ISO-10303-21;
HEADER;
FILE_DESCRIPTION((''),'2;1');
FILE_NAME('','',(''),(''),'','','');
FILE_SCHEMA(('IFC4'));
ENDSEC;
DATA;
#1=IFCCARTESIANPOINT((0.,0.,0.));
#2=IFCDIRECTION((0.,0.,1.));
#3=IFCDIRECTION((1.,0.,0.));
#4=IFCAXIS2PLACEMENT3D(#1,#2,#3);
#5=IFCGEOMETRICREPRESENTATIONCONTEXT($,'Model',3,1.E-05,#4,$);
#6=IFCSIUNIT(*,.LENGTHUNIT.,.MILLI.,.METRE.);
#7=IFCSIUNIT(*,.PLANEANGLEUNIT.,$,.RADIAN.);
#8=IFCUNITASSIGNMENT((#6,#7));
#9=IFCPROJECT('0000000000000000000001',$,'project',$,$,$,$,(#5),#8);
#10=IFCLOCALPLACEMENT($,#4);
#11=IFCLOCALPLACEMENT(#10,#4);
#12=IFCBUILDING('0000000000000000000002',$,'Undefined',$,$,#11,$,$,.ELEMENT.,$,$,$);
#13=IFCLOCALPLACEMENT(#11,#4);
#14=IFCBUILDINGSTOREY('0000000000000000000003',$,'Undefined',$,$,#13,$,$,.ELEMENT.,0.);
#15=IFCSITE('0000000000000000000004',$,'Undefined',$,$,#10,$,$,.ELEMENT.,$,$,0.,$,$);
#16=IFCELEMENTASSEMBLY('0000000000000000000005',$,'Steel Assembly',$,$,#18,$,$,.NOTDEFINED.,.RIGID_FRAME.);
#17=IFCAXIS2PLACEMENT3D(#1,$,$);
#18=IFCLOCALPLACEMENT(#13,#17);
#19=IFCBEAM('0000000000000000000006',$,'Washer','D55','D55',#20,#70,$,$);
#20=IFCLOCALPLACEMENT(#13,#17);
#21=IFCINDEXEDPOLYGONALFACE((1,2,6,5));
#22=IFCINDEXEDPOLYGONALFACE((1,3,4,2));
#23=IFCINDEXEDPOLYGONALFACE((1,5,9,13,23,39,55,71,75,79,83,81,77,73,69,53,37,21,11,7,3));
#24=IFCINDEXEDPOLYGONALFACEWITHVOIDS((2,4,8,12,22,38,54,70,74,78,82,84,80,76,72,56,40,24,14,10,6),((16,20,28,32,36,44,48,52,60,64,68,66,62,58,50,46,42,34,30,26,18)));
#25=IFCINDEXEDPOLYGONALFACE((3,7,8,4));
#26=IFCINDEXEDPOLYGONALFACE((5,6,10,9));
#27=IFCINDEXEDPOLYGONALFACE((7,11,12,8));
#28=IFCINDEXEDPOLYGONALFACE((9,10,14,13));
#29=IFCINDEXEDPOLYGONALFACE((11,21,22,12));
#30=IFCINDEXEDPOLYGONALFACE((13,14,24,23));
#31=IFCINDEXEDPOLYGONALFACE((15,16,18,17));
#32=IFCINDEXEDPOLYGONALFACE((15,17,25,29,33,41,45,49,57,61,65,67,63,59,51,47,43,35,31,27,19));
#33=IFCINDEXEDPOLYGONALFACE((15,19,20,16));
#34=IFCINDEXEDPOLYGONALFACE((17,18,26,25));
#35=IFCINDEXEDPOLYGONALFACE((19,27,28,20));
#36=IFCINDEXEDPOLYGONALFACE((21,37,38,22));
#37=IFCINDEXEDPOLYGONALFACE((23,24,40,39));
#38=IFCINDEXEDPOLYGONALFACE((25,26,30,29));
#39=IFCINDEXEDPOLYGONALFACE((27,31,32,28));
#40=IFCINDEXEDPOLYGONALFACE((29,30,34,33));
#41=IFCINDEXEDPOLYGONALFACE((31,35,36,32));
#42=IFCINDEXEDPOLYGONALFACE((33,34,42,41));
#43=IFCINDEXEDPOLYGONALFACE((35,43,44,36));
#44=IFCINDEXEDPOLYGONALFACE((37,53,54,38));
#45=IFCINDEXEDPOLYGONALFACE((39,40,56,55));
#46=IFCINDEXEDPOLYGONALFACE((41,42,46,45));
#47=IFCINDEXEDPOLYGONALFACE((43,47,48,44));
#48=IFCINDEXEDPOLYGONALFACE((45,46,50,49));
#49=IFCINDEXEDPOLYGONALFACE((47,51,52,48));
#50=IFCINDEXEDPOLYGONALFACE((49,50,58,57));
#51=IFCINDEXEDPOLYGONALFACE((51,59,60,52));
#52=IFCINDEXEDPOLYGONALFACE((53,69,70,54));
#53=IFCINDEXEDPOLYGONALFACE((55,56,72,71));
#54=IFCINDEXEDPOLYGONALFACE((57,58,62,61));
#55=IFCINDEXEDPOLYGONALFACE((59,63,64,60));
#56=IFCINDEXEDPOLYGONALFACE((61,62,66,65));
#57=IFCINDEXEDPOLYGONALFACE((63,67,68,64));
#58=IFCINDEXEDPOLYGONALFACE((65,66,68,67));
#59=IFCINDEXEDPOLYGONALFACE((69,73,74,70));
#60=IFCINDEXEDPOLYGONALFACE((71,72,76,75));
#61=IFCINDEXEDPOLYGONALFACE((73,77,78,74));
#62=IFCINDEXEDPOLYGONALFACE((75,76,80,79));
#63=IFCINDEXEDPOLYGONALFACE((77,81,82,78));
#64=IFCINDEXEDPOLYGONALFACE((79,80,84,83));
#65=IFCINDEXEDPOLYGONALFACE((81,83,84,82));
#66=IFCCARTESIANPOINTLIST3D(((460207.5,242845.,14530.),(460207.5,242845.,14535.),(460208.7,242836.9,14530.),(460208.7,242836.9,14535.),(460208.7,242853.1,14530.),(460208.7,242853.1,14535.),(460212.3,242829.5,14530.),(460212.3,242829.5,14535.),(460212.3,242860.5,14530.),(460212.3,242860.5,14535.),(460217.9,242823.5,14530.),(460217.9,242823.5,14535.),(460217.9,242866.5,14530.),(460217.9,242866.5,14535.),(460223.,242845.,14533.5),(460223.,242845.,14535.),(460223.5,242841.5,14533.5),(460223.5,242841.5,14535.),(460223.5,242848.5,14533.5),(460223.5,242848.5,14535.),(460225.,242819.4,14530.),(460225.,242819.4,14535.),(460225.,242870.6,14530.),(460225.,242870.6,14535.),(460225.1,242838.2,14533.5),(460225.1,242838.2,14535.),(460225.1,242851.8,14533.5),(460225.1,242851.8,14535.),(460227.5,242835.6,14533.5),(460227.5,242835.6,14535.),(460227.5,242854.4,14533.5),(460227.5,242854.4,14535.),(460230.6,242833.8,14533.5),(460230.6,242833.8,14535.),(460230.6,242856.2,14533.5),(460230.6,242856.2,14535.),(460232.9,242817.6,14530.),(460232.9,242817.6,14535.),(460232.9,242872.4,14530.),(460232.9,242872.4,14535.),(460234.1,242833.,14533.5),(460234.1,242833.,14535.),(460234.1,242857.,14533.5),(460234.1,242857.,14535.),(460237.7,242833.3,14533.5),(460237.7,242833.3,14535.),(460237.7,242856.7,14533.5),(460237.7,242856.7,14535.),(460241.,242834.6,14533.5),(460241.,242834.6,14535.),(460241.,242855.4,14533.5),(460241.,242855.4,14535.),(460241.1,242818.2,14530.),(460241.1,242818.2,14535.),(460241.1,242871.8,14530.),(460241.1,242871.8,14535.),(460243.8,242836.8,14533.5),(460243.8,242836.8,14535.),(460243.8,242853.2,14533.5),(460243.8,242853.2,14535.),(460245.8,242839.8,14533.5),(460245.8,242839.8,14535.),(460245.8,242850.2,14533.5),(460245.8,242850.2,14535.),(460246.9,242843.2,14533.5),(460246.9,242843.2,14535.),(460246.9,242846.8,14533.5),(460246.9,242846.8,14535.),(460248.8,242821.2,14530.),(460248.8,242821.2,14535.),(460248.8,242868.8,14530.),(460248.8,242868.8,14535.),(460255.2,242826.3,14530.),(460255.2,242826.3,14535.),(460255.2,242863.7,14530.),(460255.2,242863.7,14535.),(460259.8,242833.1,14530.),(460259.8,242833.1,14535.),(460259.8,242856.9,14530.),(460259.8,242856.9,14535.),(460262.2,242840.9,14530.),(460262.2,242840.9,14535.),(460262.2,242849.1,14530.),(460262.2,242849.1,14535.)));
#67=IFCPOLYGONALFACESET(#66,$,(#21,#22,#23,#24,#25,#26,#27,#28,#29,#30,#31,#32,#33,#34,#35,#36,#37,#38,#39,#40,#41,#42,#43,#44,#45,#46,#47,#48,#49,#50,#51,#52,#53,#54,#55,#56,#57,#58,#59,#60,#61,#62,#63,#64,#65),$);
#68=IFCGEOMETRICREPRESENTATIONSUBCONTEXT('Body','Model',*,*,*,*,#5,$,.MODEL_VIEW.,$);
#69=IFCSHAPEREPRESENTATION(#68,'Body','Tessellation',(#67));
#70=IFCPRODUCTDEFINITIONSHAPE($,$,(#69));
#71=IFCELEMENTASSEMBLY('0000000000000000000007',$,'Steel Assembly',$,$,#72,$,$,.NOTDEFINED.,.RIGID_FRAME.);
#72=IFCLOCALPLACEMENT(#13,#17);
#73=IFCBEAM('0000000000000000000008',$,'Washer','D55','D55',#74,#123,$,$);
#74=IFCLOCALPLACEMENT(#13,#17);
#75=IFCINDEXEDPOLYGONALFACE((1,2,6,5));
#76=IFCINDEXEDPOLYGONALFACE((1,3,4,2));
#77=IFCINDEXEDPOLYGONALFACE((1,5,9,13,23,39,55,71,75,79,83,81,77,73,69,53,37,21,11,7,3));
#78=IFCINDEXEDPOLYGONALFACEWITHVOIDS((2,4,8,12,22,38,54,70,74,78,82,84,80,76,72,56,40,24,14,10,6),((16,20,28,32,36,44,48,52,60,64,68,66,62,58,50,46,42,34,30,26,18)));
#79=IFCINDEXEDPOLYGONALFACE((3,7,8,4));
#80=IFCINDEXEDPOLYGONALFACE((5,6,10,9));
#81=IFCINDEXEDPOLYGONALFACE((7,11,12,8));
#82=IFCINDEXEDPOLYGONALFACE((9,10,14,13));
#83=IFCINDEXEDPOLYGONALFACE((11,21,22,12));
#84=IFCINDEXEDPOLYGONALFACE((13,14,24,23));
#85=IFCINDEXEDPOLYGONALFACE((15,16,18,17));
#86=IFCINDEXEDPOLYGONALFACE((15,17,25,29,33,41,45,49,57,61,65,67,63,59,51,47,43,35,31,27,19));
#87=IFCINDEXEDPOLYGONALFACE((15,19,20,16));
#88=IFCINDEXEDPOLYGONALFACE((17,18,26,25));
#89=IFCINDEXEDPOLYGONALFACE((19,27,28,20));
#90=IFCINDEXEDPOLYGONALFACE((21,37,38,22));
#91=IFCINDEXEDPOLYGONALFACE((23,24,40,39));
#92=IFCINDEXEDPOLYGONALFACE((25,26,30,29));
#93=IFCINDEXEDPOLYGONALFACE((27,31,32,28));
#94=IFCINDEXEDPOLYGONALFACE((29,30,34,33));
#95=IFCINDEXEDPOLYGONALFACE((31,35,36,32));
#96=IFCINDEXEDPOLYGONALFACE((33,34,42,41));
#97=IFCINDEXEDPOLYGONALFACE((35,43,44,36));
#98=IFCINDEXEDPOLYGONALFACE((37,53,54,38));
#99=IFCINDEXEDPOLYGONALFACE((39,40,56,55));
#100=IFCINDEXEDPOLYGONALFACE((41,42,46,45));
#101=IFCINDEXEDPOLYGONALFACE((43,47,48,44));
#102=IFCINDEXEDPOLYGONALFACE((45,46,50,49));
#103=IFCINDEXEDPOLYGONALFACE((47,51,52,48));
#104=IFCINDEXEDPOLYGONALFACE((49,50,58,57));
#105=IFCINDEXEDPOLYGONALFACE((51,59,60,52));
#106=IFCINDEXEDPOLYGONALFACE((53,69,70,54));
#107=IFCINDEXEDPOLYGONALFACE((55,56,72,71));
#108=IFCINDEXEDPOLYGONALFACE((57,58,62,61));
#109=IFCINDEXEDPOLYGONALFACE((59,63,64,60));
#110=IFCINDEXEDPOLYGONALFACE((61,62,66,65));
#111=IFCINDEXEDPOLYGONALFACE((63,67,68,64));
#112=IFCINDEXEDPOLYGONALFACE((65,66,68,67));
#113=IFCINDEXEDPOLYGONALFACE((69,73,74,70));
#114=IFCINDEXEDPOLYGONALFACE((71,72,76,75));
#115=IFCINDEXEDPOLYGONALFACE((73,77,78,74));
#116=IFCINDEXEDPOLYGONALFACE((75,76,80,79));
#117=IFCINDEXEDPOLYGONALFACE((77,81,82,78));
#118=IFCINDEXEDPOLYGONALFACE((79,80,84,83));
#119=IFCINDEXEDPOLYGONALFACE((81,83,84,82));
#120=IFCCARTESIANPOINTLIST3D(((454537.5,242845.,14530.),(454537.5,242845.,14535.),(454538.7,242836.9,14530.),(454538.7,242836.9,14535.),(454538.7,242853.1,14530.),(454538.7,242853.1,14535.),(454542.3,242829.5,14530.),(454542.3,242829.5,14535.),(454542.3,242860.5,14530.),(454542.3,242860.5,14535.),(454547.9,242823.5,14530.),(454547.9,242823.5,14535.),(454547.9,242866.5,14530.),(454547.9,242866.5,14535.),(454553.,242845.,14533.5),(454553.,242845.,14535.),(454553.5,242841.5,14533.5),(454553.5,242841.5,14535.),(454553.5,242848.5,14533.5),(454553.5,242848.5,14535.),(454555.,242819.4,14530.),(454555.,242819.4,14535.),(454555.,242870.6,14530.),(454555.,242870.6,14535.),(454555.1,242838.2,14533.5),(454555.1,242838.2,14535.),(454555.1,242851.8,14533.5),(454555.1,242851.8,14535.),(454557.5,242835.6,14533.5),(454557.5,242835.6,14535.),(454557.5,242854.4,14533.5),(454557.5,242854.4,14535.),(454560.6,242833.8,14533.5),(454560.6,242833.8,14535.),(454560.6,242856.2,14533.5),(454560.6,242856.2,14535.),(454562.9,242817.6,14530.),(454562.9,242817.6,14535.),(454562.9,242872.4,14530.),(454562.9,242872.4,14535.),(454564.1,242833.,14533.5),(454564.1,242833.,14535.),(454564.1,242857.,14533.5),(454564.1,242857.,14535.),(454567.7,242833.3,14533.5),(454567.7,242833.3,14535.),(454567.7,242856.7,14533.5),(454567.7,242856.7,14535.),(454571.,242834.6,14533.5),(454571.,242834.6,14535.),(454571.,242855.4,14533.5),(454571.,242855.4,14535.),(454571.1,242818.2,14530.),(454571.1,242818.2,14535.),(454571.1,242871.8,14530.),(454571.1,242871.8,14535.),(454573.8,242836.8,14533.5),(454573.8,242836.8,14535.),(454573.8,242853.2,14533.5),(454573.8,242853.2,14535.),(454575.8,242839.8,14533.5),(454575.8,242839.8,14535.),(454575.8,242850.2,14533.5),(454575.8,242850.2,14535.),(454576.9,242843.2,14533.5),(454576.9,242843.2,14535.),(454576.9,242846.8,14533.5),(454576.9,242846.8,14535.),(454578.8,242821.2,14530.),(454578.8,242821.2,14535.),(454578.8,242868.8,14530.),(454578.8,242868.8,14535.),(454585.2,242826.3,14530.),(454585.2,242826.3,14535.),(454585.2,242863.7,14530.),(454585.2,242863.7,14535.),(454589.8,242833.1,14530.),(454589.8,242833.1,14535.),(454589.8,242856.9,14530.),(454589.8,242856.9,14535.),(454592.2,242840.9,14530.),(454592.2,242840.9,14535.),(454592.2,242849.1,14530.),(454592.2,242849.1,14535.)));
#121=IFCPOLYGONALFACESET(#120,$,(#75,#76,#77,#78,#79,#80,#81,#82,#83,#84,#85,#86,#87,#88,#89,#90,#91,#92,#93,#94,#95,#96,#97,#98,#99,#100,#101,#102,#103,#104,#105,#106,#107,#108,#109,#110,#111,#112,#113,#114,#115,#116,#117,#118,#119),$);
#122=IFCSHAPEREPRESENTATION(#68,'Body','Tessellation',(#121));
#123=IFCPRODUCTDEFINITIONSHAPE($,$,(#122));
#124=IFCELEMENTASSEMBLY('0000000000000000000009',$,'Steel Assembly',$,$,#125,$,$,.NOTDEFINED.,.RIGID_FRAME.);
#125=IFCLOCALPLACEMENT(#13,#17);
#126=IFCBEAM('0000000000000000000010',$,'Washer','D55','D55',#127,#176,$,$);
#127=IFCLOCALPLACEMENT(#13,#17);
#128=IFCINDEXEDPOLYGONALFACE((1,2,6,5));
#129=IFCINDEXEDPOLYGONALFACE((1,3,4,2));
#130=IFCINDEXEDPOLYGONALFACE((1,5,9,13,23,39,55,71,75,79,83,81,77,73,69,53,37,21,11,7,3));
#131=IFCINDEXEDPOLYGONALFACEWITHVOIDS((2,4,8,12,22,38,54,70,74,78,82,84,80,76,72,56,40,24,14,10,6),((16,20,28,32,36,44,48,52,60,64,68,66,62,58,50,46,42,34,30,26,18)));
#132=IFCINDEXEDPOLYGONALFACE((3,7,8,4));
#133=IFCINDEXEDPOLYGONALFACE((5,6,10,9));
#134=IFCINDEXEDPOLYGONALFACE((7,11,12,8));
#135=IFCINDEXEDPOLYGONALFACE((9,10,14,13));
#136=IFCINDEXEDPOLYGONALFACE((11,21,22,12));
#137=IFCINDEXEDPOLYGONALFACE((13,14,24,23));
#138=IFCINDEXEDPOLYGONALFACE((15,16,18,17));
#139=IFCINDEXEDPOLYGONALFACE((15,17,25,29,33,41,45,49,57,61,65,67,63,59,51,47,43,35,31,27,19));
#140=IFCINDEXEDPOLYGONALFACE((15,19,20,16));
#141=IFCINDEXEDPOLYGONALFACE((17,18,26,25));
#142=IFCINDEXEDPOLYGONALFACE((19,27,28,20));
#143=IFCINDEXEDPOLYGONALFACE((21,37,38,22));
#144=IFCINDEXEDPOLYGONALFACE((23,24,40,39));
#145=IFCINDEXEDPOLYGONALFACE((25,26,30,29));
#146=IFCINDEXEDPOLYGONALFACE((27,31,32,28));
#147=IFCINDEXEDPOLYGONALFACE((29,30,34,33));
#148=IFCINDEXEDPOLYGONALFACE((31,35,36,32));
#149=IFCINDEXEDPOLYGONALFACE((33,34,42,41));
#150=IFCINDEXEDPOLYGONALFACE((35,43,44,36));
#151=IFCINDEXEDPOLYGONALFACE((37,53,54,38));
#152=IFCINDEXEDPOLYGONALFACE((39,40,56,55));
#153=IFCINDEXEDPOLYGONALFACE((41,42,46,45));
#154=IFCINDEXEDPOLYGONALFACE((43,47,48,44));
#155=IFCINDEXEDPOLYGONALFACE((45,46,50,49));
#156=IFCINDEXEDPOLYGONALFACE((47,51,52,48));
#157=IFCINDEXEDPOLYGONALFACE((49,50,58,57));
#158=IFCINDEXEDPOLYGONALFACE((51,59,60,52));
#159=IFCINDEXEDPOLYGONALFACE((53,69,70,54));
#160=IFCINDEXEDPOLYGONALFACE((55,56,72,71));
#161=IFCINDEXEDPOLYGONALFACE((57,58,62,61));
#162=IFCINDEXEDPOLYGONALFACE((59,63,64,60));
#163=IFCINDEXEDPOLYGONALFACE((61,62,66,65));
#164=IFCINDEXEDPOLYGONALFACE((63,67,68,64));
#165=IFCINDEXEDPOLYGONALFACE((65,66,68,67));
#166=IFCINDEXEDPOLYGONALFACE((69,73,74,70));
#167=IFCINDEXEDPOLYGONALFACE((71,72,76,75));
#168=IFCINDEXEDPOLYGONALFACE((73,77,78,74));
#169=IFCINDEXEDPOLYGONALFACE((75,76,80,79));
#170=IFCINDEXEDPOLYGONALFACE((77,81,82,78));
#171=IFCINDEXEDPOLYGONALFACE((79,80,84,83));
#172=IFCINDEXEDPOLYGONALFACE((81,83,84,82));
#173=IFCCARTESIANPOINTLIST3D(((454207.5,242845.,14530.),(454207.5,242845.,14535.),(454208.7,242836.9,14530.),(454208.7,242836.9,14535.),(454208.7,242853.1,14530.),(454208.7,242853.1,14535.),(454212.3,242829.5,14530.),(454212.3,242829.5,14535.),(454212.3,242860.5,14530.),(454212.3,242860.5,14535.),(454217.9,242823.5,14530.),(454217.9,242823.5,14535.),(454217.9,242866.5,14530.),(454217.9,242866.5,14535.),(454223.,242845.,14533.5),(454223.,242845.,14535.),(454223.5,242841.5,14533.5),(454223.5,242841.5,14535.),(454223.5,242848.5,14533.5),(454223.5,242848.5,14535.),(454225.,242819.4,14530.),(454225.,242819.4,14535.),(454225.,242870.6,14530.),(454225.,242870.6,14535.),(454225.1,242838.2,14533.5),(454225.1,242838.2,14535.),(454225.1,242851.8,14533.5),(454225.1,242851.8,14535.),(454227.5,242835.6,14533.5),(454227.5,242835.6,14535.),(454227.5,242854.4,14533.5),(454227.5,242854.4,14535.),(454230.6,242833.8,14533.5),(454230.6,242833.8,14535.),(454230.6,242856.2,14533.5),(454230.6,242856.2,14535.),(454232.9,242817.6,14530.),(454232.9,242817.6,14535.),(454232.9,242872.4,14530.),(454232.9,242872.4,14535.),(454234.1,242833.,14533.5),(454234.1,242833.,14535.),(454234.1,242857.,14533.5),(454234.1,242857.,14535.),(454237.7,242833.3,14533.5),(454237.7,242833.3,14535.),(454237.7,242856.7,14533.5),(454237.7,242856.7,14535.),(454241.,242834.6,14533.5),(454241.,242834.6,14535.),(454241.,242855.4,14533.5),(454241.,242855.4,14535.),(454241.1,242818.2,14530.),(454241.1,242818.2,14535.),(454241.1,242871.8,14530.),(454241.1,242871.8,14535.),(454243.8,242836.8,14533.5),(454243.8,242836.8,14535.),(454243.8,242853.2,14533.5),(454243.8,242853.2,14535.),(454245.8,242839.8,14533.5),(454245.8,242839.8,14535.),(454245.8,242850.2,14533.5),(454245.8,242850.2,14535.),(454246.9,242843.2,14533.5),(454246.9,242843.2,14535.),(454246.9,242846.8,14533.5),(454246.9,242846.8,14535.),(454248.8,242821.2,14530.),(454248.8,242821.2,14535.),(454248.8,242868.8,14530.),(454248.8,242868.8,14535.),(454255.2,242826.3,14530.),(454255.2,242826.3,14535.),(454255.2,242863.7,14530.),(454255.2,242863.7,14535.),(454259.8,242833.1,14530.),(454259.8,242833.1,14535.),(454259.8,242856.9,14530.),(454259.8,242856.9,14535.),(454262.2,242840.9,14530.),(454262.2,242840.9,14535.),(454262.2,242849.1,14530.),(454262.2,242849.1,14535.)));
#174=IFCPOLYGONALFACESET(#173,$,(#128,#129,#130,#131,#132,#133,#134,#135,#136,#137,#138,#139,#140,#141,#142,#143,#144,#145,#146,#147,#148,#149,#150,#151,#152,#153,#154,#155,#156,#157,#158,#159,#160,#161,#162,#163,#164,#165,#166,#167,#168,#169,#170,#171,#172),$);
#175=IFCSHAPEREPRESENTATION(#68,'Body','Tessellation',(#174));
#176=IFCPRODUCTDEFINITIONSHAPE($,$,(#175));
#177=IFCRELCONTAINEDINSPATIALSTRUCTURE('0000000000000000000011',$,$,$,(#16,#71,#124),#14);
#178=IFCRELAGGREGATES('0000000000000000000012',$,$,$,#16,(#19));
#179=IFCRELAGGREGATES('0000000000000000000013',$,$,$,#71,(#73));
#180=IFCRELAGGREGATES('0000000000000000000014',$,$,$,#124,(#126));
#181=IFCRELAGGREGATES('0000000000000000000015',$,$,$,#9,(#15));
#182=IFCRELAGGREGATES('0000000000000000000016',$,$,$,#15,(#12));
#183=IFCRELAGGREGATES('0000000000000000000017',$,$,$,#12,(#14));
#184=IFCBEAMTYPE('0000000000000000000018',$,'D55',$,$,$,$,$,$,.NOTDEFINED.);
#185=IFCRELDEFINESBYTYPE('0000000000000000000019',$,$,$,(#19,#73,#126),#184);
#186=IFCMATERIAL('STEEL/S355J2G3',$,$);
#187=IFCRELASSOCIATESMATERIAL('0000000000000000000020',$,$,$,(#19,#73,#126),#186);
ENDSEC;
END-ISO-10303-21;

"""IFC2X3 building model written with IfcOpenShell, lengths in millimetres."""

from ifc_helpers import new_model, si_unit, frame, origin_with_axes, origin_2d_with_axis, place, context, subcontext, project, spatial, circle, extrude, boolean, material, type_object, element, aggregate, save


model = new_model("IFC2X3")

# Units and contexts
model_context = context("Model", 3, precision=1e-05, world=origin_with_axes())
body_context = subcontext(model_context, "Body", "Model", "MODEL_VIEW")
ifc_project = project(units=[si_unit("LENGTHUNIT", "METRE", prefix="MILLI"), si_unit("PLANEANGLEUNIT", "RADIAN")], contexts=[model_context])

# Site, building, storey
site_placement = place(None, origin_with_axes())
site = spatial("IfcSite", under=ifc_project, at=site_placement, Name="Undefined", CompositionType="ELEMENT", RefElevation=0.0)
building_placement = place(site_placement, origin_with_axes())
building = spatial("IfcBuilding", under=site, at=building_placement, Name="Undefined", CompositionType="ELEMENT")
storey_placement = place(building_placement, origin_with_axes())
storey = spatial("IfcBuildingStorey", under=building, at=storey_placement, Name="Undefined", CompositionType="ELEMENT", Elevation=0.0)

# Element assemblies, beams
ifc_material_1 = material(Name="STEEL/S355J2G3")
assembly_1_placement = place(storey_placement, origin_with_axes())
assembly_1 = element("IfcElementAssembly", 1, at=assembly_1_placement, inside=storey, Name="Steel Assembly", AssemblyPlace="NOTDEFINED", PredefinedType="RIGID_FRAME")
beam_type_1 = type_object("IfcBeamType", Name="D55", PredefinedType="NOTDEFINED")
beam_1_placement = place(assembly_1_placement, frame((460235.0, 242845.0, 14535.0), z_axis=(0.0, -1.0, 0.0), x_axis=(0.0, 0.0, -1.0)))
beam_1 = element("IfcBeam", 2, at=beam_1_placement, type_object=beam_type_1, material=ifc_material_1, Name="Washer", Description="D55", ObjectType="D55", context=body_context, shape_type="CSG", body=[
    boolean("DIFFERENCE", extrude(circle(Radius=27.5, at=origin_2d_with_axis()), frame((5.0, 0.0, 0.0), z_axis=(-1.0, 0.0, 0.0), x_axis=(0.0, -1.0, 0.0)), (0.0, 0.0, 1.0), 5.0), extrude(circle(Radius=12.0, at=origin_2d_with_axis()), frame((1.5, 0.0, 0.0), z_axis=(-1.0, 0.0, 0.0), x_axis=(0.0, -1.0, 0.0)), (0.0, 0.0, 1.0), 10.0)),
])
aggregate(assembly_1, [beam_1])
assembly_2_placement = place(storey_placement, origin_with_axes())
assembly_2 = element("IfcElementAssembly", 3, at=assembly_2_placement, inside=storey, Name="Steel Assembly", AssemblyPlace="NOTDEFINED", PredefinedType="RIGID_FRAME")
beam_2_placement = place(assembly_2_placement, frame((454565.0, 242845.0, 14535.0), z_axis=(0.0, -1.0, 0.0), x_axis=(0.0, 0.0, -1.0)))
beam_2 = element("IfcBeam", 4, at=beam_2_placement, type_object=beam_type_1, material=ifc_material_1, Name="Washer", Description="D55", ObjectType="D55", context=body_context, shape_type="CSG", body=[
    boolean("DIFFERENCE", extrude(circle(Radius=27.5, at=origin_2d_with_axis()), frame((5.0, 0.0, 0.0), z_axis=(-1.0, 0.0, 0.0), x_axis=(0.0, -1.0, 0.0)), (0.0, 0.0, 1.0), 5.0), extrude(circle(Radius=12.0, at=origin_2d_with_axis()), frame((1.5, 0.0, 0.0), z_axis=(-1.0, 0.0, 0.0), x_axis=(0.0, -1.0, 0.0)), (0.0, 0.0, 1.0), 10.0)),
])
aggregate(assembly_2, [beam_2])
assembly_3_placement = place(storey_placement, origin_with_axes())
assembly_3 = element("IfcElementAssembly", 5, at=assembly_3_placement, inside=storey, Name="Steel Assembly", AssemblyPlace="NOTDEFINED", PredefinedType="RIGID_FRAME")
beam_3_placement = place(assembly_3_placement, frame((454235.0, 242845.0, 14535.0), z_axis=(0.0, -1.0, 0.0), x_axis=(0.0, 0.0, -1.0)))
beam_3 = element("IfcBeam", 6, at=beam_3_placement, type_object=beam_type_1, material=ifc_material_1, Name="Washer", Description="D55", ObjectType="D55", context=body_context, shape_type="CSG", body=[
    boolean("DIFFERENCE", extrude(circle(Radius=27.5, at=origin_2d_with_axis()), frame((5.0, 0.0, 0.0), z_axis=(-1.0, 0.0, 0.0), x_axis=(0.0, -1.0, 0.0)), (0.0, 0.0, 1.0), 5.0), extrude(circle(Radius=12.0, at=origin_2d_with_axis()), frame((1.5, 0.0, 0.0), z_axis=(-1.0, 0.0, 0.0), x_axis=(0.0, -1.0, 0.0)), (0.0, 0.0, 1.0), 10.0)),
])
aggregate(assembly_3, [beam_3])

save(model, "model.ifc")
